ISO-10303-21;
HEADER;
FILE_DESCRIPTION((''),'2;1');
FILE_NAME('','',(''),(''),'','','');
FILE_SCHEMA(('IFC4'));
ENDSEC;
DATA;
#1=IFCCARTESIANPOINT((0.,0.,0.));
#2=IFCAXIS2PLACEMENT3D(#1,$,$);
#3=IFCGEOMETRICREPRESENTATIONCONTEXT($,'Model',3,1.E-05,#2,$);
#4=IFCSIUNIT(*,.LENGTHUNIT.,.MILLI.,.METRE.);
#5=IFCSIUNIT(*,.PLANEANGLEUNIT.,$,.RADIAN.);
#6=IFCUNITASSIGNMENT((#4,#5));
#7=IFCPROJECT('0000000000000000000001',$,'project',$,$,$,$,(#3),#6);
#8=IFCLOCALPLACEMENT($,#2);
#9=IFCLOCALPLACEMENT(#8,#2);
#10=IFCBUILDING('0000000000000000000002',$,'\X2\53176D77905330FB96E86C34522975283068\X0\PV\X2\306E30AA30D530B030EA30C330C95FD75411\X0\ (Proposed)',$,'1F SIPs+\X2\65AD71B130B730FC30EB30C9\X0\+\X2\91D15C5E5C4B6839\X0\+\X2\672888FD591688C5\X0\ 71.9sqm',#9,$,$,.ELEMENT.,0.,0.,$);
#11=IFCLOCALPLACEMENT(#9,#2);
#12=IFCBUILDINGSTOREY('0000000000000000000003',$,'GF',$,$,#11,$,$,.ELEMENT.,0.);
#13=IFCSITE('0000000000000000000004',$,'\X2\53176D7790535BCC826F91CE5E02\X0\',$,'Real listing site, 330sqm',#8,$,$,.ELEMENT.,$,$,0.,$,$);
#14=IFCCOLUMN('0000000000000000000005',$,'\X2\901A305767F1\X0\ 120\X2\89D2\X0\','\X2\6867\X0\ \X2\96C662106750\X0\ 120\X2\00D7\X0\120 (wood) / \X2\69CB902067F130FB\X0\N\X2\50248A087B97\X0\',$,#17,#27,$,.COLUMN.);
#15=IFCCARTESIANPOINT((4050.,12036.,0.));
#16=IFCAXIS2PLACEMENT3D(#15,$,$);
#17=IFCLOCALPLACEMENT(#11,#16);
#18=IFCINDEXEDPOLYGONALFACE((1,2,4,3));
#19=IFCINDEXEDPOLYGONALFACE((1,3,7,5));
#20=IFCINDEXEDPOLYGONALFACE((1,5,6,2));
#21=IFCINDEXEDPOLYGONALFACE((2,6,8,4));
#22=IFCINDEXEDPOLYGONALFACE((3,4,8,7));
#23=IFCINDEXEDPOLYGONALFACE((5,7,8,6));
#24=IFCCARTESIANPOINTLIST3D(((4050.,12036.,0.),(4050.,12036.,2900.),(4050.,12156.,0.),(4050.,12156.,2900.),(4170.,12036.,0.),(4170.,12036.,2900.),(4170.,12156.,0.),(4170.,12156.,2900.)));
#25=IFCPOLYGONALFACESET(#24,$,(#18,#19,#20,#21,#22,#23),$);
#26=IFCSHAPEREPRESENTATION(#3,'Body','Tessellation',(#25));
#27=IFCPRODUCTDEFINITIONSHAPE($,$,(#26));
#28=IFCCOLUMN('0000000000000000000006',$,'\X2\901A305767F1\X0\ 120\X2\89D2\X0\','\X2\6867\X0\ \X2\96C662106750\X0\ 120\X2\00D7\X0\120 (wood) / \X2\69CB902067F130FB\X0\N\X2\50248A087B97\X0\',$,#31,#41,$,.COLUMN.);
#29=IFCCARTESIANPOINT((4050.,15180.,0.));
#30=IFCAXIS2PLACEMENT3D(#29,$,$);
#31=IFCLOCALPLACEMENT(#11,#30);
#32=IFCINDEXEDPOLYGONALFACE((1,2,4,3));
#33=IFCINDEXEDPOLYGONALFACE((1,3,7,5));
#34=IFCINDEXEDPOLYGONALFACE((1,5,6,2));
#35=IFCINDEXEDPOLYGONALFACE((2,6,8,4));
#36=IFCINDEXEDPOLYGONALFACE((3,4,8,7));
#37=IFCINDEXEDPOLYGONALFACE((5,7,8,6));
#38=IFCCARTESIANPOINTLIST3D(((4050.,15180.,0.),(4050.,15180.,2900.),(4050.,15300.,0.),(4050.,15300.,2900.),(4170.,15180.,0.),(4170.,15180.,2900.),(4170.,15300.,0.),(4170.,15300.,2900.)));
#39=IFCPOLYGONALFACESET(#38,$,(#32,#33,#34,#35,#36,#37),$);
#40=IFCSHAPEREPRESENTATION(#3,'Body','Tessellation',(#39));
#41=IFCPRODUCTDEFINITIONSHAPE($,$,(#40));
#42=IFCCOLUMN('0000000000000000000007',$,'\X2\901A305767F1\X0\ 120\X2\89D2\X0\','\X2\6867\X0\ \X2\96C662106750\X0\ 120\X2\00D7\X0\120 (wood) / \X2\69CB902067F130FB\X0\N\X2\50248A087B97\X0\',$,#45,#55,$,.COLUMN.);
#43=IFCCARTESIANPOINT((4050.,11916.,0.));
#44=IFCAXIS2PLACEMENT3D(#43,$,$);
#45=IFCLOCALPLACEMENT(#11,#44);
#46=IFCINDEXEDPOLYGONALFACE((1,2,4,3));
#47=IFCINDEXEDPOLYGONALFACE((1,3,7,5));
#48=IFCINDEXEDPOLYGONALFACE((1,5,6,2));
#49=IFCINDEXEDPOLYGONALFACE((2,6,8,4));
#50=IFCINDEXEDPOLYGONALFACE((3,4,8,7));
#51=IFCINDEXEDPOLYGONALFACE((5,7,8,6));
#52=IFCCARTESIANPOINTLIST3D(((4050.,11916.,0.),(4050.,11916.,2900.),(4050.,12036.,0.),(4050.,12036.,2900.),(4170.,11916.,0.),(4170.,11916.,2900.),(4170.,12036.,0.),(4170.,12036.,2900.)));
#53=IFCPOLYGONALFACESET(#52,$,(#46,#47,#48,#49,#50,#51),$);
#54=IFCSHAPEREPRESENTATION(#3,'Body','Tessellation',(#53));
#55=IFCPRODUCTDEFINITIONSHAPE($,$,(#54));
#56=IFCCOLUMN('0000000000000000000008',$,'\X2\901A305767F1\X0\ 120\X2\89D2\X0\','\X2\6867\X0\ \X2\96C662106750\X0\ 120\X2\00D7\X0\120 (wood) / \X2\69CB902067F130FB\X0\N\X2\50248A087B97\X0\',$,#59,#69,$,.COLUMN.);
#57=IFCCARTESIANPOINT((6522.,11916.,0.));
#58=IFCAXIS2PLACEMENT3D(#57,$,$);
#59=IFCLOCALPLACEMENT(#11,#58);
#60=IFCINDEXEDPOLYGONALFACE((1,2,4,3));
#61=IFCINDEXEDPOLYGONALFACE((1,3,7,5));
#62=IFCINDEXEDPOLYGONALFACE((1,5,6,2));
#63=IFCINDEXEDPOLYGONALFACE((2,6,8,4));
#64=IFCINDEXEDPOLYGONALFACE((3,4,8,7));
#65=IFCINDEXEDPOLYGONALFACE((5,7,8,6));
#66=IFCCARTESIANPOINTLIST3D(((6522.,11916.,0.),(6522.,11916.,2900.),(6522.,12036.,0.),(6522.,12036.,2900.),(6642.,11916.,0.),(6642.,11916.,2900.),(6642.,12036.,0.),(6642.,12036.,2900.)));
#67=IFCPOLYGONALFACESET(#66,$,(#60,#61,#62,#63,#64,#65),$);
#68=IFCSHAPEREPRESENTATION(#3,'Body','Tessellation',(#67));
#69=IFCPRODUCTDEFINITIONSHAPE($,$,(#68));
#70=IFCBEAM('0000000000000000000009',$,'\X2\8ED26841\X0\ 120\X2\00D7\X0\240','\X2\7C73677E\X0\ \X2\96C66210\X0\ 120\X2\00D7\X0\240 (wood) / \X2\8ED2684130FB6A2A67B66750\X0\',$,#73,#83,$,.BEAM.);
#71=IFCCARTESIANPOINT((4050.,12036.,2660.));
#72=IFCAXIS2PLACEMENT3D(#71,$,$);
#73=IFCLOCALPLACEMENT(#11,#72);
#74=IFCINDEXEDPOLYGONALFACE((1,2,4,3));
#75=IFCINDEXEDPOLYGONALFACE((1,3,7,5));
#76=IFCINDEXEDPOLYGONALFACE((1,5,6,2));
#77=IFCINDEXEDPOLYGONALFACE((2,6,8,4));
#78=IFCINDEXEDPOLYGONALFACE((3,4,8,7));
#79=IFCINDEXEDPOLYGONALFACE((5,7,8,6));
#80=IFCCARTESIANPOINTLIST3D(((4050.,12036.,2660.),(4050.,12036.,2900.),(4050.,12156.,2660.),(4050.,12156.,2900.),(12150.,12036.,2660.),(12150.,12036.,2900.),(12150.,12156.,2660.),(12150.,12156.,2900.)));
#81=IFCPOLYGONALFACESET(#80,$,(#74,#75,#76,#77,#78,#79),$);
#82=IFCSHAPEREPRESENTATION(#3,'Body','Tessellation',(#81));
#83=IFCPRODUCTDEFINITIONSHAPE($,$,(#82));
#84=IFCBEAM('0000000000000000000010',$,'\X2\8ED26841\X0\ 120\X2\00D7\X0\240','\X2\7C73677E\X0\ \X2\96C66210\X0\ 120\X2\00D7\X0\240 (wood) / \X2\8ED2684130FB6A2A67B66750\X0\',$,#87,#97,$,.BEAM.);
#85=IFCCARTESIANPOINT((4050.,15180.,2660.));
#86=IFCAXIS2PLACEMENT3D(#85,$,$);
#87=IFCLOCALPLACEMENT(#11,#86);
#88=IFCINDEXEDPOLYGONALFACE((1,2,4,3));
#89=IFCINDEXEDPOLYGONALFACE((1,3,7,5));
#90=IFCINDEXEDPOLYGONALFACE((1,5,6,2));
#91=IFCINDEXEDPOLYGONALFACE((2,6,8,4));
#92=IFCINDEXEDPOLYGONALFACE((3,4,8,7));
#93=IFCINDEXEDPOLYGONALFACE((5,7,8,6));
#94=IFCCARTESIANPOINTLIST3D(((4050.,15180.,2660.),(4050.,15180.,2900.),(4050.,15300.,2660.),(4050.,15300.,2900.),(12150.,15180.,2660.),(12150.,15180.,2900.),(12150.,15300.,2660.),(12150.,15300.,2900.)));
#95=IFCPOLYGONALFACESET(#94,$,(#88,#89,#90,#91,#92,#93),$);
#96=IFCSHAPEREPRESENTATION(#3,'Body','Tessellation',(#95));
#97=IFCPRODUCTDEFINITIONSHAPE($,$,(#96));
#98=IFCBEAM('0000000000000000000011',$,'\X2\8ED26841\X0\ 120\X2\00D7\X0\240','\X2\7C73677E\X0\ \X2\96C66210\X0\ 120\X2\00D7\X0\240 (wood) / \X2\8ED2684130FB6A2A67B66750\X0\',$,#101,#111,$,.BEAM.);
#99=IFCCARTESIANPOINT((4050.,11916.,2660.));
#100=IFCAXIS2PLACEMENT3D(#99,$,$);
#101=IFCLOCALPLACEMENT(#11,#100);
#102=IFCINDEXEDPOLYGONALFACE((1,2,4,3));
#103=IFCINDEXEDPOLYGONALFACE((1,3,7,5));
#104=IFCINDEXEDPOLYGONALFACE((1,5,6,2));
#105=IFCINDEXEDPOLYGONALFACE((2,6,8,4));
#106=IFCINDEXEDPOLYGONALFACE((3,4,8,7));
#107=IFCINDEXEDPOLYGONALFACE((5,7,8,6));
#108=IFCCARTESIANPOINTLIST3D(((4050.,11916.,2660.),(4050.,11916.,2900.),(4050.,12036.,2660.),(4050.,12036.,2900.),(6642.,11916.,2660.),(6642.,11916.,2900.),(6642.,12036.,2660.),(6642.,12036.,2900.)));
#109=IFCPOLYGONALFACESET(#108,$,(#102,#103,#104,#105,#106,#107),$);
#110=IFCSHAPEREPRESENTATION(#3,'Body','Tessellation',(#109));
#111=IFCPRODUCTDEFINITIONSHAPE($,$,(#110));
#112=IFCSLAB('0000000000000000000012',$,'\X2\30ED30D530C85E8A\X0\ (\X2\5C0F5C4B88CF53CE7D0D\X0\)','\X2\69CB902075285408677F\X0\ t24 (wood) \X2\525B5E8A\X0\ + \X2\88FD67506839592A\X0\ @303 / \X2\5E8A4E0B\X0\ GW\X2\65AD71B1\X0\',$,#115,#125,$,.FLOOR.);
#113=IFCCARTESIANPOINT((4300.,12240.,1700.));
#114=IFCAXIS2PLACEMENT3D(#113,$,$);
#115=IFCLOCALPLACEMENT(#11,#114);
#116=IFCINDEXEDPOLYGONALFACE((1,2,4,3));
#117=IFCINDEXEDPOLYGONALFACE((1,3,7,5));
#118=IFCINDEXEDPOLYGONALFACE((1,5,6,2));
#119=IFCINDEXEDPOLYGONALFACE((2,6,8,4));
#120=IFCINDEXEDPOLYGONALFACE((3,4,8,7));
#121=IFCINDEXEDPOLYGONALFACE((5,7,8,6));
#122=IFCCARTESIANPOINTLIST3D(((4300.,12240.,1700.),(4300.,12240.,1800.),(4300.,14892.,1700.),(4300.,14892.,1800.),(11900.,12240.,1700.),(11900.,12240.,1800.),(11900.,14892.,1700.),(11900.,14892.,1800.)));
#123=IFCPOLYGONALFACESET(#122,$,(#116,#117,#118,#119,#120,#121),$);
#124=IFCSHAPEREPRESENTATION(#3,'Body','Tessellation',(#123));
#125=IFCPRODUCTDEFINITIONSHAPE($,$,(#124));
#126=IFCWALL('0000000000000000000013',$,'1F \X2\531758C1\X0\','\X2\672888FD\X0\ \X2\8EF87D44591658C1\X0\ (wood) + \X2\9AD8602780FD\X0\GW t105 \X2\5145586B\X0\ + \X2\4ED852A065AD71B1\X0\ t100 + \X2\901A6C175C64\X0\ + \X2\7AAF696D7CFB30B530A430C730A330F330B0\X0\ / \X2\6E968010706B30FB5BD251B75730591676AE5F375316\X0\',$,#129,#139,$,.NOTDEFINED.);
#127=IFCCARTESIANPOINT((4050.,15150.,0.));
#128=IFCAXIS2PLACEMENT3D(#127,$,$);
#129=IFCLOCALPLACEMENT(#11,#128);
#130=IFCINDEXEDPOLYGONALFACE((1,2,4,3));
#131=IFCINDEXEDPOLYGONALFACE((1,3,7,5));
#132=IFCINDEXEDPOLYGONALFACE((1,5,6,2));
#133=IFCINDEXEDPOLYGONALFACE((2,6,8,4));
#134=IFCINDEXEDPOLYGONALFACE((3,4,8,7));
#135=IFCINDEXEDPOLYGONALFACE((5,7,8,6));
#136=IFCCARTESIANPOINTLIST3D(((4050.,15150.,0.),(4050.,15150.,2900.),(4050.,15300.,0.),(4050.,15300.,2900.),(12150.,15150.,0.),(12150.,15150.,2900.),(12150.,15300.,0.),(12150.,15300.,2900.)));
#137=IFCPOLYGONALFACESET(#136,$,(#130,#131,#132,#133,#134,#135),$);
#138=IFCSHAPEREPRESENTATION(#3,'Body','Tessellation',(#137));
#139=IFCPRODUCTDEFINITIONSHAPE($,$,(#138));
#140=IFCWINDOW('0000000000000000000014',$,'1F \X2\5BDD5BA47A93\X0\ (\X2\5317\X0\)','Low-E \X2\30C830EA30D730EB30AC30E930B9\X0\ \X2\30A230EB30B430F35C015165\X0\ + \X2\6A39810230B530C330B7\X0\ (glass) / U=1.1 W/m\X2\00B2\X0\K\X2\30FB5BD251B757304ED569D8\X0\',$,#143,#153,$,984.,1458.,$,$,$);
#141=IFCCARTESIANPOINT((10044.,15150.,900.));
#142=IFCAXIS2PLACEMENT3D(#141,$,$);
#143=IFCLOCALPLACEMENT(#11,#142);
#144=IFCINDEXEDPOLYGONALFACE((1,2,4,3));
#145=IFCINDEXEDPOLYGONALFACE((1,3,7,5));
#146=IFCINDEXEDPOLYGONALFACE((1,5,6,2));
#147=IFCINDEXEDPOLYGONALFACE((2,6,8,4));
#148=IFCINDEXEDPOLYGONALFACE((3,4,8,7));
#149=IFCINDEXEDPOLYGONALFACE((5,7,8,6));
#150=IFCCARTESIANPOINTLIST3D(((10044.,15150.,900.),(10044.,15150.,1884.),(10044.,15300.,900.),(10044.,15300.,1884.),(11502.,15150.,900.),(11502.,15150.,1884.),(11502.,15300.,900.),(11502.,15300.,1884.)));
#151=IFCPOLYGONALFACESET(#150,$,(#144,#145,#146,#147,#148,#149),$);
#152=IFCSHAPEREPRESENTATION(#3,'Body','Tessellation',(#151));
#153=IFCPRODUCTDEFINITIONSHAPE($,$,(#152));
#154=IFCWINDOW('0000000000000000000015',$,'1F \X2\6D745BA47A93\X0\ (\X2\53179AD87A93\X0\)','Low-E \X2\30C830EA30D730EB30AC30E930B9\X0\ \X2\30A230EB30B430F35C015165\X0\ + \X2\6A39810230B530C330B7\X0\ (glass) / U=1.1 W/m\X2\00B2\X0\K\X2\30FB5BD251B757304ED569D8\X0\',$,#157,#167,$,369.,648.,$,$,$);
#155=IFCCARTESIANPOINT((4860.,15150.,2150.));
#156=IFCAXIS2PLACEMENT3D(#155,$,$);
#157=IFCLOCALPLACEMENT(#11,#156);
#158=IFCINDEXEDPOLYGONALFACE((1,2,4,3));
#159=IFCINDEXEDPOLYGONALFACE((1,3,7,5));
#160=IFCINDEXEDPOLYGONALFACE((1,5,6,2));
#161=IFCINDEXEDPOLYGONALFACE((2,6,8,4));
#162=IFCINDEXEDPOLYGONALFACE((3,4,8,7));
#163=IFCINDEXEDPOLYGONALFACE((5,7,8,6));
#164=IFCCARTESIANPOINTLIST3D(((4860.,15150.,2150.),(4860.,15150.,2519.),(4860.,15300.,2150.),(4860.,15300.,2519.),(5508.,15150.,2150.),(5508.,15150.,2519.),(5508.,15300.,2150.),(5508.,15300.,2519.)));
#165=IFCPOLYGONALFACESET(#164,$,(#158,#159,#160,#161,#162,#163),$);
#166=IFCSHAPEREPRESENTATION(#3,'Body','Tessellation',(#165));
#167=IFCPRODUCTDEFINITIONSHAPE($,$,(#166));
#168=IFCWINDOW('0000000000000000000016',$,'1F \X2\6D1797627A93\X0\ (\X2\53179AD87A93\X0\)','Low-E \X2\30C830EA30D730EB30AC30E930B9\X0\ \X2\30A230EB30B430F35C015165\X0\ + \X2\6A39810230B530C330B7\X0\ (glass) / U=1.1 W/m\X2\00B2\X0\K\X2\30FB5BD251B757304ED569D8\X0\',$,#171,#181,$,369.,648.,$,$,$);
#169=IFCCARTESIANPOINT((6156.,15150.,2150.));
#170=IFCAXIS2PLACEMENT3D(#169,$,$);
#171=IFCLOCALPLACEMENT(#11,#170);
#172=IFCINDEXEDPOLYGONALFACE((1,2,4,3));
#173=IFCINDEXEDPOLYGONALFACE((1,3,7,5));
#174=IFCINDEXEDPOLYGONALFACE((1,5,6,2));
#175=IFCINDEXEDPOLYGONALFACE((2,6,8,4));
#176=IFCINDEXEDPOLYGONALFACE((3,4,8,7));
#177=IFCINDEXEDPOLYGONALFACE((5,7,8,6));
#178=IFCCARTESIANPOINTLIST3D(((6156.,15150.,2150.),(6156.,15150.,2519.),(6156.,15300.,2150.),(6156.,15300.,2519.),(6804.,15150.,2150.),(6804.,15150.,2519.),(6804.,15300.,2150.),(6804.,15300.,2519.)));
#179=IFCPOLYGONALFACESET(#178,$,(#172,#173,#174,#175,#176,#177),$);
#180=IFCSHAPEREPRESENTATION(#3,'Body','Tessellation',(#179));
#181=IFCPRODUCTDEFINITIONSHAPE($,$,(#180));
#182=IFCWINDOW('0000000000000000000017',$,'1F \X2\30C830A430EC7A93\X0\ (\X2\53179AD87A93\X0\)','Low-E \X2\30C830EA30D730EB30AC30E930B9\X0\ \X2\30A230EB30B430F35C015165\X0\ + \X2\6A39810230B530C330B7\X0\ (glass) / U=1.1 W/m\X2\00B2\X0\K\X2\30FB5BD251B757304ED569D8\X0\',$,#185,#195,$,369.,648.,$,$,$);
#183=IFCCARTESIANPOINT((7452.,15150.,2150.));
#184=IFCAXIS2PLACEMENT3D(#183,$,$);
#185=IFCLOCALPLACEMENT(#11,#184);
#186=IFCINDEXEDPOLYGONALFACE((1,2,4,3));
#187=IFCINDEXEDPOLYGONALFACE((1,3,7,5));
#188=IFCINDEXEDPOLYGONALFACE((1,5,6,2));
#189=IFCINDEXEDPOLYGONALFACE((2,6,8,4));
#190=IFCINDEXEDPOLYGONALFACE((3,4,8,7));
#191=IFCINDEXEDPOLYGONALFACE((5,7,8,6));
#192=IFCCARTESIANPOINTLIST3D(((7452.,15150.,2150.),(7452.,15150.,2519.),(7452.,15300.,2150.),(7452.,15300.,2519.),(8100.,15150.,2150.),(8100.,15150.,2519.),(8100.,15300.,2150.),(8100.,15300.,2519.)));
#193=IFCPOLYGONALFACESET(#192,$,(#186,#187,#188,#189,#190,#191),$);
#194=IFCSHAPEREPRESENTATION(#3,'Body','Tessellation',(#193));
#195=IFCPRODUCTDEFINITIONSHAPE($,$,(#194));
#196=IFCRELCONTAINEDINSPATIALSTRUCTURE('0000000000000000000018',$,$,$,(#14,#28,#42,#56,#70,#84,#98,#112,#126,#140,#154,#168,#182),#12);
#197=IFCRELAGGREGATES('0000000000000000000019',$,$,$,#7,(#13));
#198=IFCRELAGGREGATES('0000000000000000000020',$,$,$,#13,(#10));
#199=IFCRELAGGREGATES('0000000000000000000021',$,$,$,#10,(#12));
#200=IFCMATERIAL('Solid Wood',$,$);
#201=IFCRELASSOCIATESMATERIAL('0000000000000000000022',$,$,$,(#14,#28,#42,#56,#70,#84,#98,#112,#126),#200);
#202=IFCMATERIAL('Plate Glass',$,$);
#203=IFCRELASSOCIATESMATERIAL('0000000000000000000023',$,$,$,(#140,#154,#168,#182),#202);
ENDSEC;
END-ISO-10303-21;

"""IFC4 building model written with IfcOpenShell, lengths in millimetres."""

from ifc_helpers import new_model, si_unit, frame, frame_2d, origin, place, context, project, spatial, rectangle, extrude, material, element, fill, save


model = new_model("IFC4")

# Units and contexts
model_context = context("Model", 3, precision=1e-05, world=origin())
ifc_project = project(units=[si_unit("LENGTHUNIT", "METRE", prefix="MILLI"), si_unit("PLANEANGLEUNIT", "RADIAN")], contexts=[model_context])

# Site, building, storey
site_placement = place(None, origin())
site = spatial("IfcSite", under=ifc_project, at=site_placement, Name="北海道富良野市", ObjectType="Real listing site, 330sqm", CompositionType="ELEMENT", RefElevation=0.0)
building_placement = place(site_placement, origin())
building = spatial("IfcBuilding", under=site, at=building_placement, Name="北海道・雨水利用とPVのオフグリッド志向 (Proposed)", ObjectType="1F SIPs+断熱シールド+金属屋根+木製外装 71.9sqm", CompositionType="ELEMENT", ElevationOfRefHeight=0.0, ElevationOfTerrain=0.0)
storey_placement = place(building_placement, origin())
storey = spatial("IfcBuildingStorey", under=building, at=storey_placement, Name="GF", CompositionType="ELEMENT", Elevation=0.0)

# Columns
ifc_material_1 = material(Name="Solid Wood")
column_1_placement = place(storey_placement, frame((4050.0, 12036.0, 0.0)))
element("IfcColumn", 1, at=column_1_placement, inside=storey, material=ifc_material_1, Name="通し柱 120角", Description="桧 集成材 120×120 (wood) / 構造柱・N値計算", PredefinedType="COLUMN", context=model_context, shape_type="SweptSolid", body=[
    extrude(rectangle(XDim=120.0, YDim=120.0, at=frame_2d((60.0, 60.0))), frame((4050.0, 12036.0, 0.0)), (0.0, 0.0, 1.0), 2900.0),
])
column_2_placement = place(storey_placement, frame((4050.0, 15180.0, 0.0)))
element("IfcColumn", 2, at=column_2_placement, inside=storey, material=ifc_material_1, Name="通し柱 120角", Description="桧 集成材 120×120 (wood) / 構造柱・N値計算", PredefinedType="COLUMN", context=model_context, shape_type="SweptSolid", body=[
    extrude(rectangle(XDim=120.0, YDim=120.0, at=frame_2d((60.0, 60.0))), frame((4050.0, 15180.0, 0.0)), (0.0, 0.0, 1.0), 2900.0),
])
column_3_placement = place(storey_placement, frame((4050.0, 11916.0, 0.0)))
element("IfcColumn", 3, at=column_3_placement, inside=storey, material=ifc_material_1, Name="通し柱 120角", Description="桧 集成材 120×120 (wood) / 構造柱・N値計算", PredefinedType="COLUMN", context=model_context, shape_type="SweptSolid", body=[
    extrude(rectangle(XDim=120.0, YDim=120.0, at=frame_2d((60.0, 60.0))), frame((4050.0, 11916.0, 0.0)), (0.0, 0.0, 1.0), 2900.0),
])
column_4_placement = place(storey_placement, frame((6522.0, 11916.0, 0.0)))
element("IfcColumn", 4, at=column_4_placement, inside=storey, material=ifc_material_1, Name="通し柱 120角", Description="桧 集成材 120×120 (wood) / 構造柱・N値計算", PredefinedType="COLUMN", context=model_context, shape_type="SweptSolid", body=[
    extrude(rectangle(XDim=120.0, YDim=120.0, at=frame_2d((60.0, 60.0))), frame((6522.0, 11916.0, 0.0)), (0.0, 0.0, 1.0), 2900.0),
])

# Beams
beam_1_placement = place(storey_placement, frame((4050.0, 12036.0, 2660.0)))
element("IfcBeam", 5, at=beam_1_placement, inside=storey, material=ifc_material_1, Name="軒桁 120×240", Description="米松 集成 120×240 (wood) / 軒桁・横架材", PredefinedType="BEAM", context=model_context, shape_type="SweptSolid", body=[
    extrude(rectangle(XDim=8100.0, YDim=120.0, at=frame_2d((4050.0, 60.0))), frame((4050.0, 12036.0, 2660.0)), (0.0, 0.0, 1.0), 240.0),
])
beam_2_placement = place(storey_placement, frame((4050.0, 15180.0, 2660.0)))
element("IfcBeam", 6, at=beam_2_placement, inside=storey, material=ifc_material_1, Name="軒桁 120×240", Description="米松 集成 120×240 (wood) / 軒桁・横架材", PredefinedType="BEAM", context=model_context, shape_type="SweptSolid", body=[
    extrude(rectangle(XDim=8100.0, YDim=120.0, at=frame_2d((4050.0, 60.0))), frame((4050.0, 15180.0, 2660.0)), (0.0, 0.0, 1.0), 240.0),
])
beam_3_placement = place(storey_placement, frame((4050.0, 11916.0, 2660.0)))
element("IfcBeam", 7, at=beam_3_placement, inside=storey, material=ifc_material_1, Name="軒桁 120×240", Description="米松 集成 120×240 (wood) / 軒桁・横架材", PredefinedType="BEAM", context=model_context, shape_type="SweptSolid", body=[
    extrude(rectangle(XDim=2592.0, YDim=120.0, at=frame_2d((1296.0, 60.0))), frame((4050.0, 11916.0, 2660.0)), (0.0, 0.0, 1.0), 240.0),
])

# Slab
slab_1_placement = place(storey_placement, frame((4300.0, 12240.0, 1700.0)))
element("IfcSlab", 8, at=slab_1_placement, inside=storey, material=ifc_material_1, Name="ロフト床 (小屋裏収納)", Description="構造用合板 t24 (wood) 剛床 + 製材根太 @303 / 床下 GW断熱", PredefinedType="FLOOR", context=model_context, shape_type="SweptSolid", body=[
    extrude(rectangle(XDim=7600.0, YDim=2652.0, at=frame_2d((3800.0, 1326.0))), frame((4300.0, 12240.0, 1700.0)), (0.0, 0.0, 1.0), 100.0),
])

# Wall, openings, windows
wall_1_placement = place(storey_placement, frame((4050.0, 15150.0, 0.0)))
wall_1 = element("IfcWall", 9, at=wall_1_placement, inside=storey, material=ifc_material_1, Name="1F 北壁", Description="木製 軸組外壁 (wood) + 高性能GW t105 充填 + 付加断熱 t100 + 通気層 + 窯業系サイディング / 準耐火・寒冷地外皮強化", PredefinedType="NOTDEFINED", context=model_context, shape_type="SweptSolid", body=[
    extrude(rectangle(XDim=8100.0, YDim=150.0, at=frame_2d((4050.0, 75.0))), frame((4050.0, 15150.0, 0.0)), (0.0, 0.0, 1.0), 2900.0),
])
opening_1_placement = place(storey_placement, frame((10044.0, 15150.0, 900.0)))
opening_1 = element("IfcOpeningElement", 10, at=opening_1_placement, cuts=wall_1, PredefinedType="NOTDEFINED", context=model_context, shape_type="SweptSolid", body=[
    extrude(rectangle(XDim=1458.0, YDim=150.0, at=frame_2d((729.0, 75.0))), frame((10044.0, 15150.0, 900.0)), (0.0, 0.0, 1.0), 984.0),
])
opening_2_placement = place(storey_placement, frame((4860.0, 15150.0, 2150.0)))
opening_2 = element("IfcOpeningElement", 11, at=opening_2_placement, cuts=wall_1, PredefinedType="NOTDEFINED", context=model_context, shape_type="SweptSolid", body=[
    extrude(rectangle(XDim=648.0, YDim=150.0, at=frame_2d((324.0, 75.0))), frame((4860.0, 15150.0, 2150.0)), (0.0, 0.0, 1.0), 369.0),
])
opening_3_placement = place(storey_placement, frame((6156.0, 15150.0, 2150.0)))
opening_3 = element("IfcOpeningElement", 12, at=opening_3_placement, cuts=wall_1, PredefinedType="NOTDEFINED", context=model_context, shape_type="SweptSolid", body=[
    extrude(rectangle(XDim=648.0, YDim=150.0, at=frame_2d((324.0, 75.0))), frame((6156.0, 15150.0, 2150.0)), (0.0, 0.0, 1.0), 369.0),
])
opening_4_placement = place(storey_placement, frame((7452.0, 15150.0, 2150.0)))
opening_4 = element("IfcOpeningElement", 13, at=opening_4_placement, cuts=wall_1, PredefinedType="NOTDEFINED", context=model_context, shape_type="SweptSolid", body=[
    extrude(rectangle(XDim=648.0, YDim=150.0, at=frame_2d((324.0, 75.0))), frame((7452.0, 15150.0, 2150.0)), (0.0, 0.0, 1.0), 369.0),
])
ifc_material_2 = material(Name="Plate Glass")
window_1_placement = place(storey_placement, frame((10044.0, 15150.0, 900.0)))
window_1 = element("IfcWindow", 14, at=window_1_placement, inside=storey, material=ifc_material_2, Name="1F 寝室窓 (北)", Description="Low-E トリプルガラス アルゴン封入 + 樹脂サッシ (glass) / U=1.1 W/m²K・寒冷地仕様", OverallHeight=984.0, OverallWidth=1458.0, context=model_context, shape_type="SweptSolid", body=[
    extrude(rectangle(XDim=1458.0, YDim=150.0, at=frame_2d((729.0, 75.0))), frame((10044.0, 15150.0, 900.0)), (0.0, 0.0, 1.0), 984.0),
])
fill(opening_1, window_1)
window_2_placement = place(storey_placement, frame((4860.0, 15150.0, 2150.0)))
window_2 = element("IfcWindow", 15, at=window_2_placement, inside=storey, material=ifc_material_2, Name="1F 浴室窓 (北高窓)", Description="Low-E トリプルガラス アルゴン封入 + 樹脂サッシ (glass) / U=1.1 W/m²K・寒冷地仕様", OverallHeight=369.0, OverallWidth=648.0, context=model_context, shape_type="SweptSolid", body=[
    extrude(rectangle(XDim=648.0, YDim=150.0, at=frame_2d((324.0, 75.0))), frame((4860.0, 15150.0, 2150.0)), (0.0, 0.0, 1.0), 369.0),
])
fill(opening_2, window_2)
window_3_placement = place(storey_placement, frame((6156.0, 15150.0, 2150.0)))
window_3 = element("IfcWindow", 16, at=window_3_placement, inside=storey, material=ifc_material_2, Name="1F 洗面窓 (北高窓)", Description="Low-E トリプルガラス アルゴン封入 + 樹脂サッシ (glass) / U=1.1 W/m²K・寒冷地仕様", OverallHeight=369.0, OverallWidth=648.0, context=model_context, shape_type="SweptSolid", body=[
    extrude(rectangle(XDim=648.0, YDim=150.0, at=frame_2d((324.0, 75.0))), frame((6156.0, 15150.0, 2150.0)), (0.0, 0.0, 1.0), 369.0),
])
fill(opening_3, window_3)
window_4_placement = place(storey_placement, frame((7452.0, 15150.0, 2150.0)))
window_4 = element("IfcWindow", 17, at=window_4_placement, inside=storey, material=ifc_material_2, Name="1F トイレ窓 (北高窓)", Description="Low-E トリプルガラス アルゴン封入 + 樹脂サッシ (glass) / U=1.1 W/m²K・寒冷地仕様", OverallHeight=369.0, OverallWidth=648.0, context=model_context, shape_type="SweptSolid", body=[
    extrude(rectangle(XDim=648.0, YDim=150.0, at=frame_2d((324.0, 75.0))), frame((7452.0, 15150.0, 2150.0)), (0.0, 0.0, 1.0), 369.0),
])
fill(opening_4, window_4)

save(model, "model.ifc")
